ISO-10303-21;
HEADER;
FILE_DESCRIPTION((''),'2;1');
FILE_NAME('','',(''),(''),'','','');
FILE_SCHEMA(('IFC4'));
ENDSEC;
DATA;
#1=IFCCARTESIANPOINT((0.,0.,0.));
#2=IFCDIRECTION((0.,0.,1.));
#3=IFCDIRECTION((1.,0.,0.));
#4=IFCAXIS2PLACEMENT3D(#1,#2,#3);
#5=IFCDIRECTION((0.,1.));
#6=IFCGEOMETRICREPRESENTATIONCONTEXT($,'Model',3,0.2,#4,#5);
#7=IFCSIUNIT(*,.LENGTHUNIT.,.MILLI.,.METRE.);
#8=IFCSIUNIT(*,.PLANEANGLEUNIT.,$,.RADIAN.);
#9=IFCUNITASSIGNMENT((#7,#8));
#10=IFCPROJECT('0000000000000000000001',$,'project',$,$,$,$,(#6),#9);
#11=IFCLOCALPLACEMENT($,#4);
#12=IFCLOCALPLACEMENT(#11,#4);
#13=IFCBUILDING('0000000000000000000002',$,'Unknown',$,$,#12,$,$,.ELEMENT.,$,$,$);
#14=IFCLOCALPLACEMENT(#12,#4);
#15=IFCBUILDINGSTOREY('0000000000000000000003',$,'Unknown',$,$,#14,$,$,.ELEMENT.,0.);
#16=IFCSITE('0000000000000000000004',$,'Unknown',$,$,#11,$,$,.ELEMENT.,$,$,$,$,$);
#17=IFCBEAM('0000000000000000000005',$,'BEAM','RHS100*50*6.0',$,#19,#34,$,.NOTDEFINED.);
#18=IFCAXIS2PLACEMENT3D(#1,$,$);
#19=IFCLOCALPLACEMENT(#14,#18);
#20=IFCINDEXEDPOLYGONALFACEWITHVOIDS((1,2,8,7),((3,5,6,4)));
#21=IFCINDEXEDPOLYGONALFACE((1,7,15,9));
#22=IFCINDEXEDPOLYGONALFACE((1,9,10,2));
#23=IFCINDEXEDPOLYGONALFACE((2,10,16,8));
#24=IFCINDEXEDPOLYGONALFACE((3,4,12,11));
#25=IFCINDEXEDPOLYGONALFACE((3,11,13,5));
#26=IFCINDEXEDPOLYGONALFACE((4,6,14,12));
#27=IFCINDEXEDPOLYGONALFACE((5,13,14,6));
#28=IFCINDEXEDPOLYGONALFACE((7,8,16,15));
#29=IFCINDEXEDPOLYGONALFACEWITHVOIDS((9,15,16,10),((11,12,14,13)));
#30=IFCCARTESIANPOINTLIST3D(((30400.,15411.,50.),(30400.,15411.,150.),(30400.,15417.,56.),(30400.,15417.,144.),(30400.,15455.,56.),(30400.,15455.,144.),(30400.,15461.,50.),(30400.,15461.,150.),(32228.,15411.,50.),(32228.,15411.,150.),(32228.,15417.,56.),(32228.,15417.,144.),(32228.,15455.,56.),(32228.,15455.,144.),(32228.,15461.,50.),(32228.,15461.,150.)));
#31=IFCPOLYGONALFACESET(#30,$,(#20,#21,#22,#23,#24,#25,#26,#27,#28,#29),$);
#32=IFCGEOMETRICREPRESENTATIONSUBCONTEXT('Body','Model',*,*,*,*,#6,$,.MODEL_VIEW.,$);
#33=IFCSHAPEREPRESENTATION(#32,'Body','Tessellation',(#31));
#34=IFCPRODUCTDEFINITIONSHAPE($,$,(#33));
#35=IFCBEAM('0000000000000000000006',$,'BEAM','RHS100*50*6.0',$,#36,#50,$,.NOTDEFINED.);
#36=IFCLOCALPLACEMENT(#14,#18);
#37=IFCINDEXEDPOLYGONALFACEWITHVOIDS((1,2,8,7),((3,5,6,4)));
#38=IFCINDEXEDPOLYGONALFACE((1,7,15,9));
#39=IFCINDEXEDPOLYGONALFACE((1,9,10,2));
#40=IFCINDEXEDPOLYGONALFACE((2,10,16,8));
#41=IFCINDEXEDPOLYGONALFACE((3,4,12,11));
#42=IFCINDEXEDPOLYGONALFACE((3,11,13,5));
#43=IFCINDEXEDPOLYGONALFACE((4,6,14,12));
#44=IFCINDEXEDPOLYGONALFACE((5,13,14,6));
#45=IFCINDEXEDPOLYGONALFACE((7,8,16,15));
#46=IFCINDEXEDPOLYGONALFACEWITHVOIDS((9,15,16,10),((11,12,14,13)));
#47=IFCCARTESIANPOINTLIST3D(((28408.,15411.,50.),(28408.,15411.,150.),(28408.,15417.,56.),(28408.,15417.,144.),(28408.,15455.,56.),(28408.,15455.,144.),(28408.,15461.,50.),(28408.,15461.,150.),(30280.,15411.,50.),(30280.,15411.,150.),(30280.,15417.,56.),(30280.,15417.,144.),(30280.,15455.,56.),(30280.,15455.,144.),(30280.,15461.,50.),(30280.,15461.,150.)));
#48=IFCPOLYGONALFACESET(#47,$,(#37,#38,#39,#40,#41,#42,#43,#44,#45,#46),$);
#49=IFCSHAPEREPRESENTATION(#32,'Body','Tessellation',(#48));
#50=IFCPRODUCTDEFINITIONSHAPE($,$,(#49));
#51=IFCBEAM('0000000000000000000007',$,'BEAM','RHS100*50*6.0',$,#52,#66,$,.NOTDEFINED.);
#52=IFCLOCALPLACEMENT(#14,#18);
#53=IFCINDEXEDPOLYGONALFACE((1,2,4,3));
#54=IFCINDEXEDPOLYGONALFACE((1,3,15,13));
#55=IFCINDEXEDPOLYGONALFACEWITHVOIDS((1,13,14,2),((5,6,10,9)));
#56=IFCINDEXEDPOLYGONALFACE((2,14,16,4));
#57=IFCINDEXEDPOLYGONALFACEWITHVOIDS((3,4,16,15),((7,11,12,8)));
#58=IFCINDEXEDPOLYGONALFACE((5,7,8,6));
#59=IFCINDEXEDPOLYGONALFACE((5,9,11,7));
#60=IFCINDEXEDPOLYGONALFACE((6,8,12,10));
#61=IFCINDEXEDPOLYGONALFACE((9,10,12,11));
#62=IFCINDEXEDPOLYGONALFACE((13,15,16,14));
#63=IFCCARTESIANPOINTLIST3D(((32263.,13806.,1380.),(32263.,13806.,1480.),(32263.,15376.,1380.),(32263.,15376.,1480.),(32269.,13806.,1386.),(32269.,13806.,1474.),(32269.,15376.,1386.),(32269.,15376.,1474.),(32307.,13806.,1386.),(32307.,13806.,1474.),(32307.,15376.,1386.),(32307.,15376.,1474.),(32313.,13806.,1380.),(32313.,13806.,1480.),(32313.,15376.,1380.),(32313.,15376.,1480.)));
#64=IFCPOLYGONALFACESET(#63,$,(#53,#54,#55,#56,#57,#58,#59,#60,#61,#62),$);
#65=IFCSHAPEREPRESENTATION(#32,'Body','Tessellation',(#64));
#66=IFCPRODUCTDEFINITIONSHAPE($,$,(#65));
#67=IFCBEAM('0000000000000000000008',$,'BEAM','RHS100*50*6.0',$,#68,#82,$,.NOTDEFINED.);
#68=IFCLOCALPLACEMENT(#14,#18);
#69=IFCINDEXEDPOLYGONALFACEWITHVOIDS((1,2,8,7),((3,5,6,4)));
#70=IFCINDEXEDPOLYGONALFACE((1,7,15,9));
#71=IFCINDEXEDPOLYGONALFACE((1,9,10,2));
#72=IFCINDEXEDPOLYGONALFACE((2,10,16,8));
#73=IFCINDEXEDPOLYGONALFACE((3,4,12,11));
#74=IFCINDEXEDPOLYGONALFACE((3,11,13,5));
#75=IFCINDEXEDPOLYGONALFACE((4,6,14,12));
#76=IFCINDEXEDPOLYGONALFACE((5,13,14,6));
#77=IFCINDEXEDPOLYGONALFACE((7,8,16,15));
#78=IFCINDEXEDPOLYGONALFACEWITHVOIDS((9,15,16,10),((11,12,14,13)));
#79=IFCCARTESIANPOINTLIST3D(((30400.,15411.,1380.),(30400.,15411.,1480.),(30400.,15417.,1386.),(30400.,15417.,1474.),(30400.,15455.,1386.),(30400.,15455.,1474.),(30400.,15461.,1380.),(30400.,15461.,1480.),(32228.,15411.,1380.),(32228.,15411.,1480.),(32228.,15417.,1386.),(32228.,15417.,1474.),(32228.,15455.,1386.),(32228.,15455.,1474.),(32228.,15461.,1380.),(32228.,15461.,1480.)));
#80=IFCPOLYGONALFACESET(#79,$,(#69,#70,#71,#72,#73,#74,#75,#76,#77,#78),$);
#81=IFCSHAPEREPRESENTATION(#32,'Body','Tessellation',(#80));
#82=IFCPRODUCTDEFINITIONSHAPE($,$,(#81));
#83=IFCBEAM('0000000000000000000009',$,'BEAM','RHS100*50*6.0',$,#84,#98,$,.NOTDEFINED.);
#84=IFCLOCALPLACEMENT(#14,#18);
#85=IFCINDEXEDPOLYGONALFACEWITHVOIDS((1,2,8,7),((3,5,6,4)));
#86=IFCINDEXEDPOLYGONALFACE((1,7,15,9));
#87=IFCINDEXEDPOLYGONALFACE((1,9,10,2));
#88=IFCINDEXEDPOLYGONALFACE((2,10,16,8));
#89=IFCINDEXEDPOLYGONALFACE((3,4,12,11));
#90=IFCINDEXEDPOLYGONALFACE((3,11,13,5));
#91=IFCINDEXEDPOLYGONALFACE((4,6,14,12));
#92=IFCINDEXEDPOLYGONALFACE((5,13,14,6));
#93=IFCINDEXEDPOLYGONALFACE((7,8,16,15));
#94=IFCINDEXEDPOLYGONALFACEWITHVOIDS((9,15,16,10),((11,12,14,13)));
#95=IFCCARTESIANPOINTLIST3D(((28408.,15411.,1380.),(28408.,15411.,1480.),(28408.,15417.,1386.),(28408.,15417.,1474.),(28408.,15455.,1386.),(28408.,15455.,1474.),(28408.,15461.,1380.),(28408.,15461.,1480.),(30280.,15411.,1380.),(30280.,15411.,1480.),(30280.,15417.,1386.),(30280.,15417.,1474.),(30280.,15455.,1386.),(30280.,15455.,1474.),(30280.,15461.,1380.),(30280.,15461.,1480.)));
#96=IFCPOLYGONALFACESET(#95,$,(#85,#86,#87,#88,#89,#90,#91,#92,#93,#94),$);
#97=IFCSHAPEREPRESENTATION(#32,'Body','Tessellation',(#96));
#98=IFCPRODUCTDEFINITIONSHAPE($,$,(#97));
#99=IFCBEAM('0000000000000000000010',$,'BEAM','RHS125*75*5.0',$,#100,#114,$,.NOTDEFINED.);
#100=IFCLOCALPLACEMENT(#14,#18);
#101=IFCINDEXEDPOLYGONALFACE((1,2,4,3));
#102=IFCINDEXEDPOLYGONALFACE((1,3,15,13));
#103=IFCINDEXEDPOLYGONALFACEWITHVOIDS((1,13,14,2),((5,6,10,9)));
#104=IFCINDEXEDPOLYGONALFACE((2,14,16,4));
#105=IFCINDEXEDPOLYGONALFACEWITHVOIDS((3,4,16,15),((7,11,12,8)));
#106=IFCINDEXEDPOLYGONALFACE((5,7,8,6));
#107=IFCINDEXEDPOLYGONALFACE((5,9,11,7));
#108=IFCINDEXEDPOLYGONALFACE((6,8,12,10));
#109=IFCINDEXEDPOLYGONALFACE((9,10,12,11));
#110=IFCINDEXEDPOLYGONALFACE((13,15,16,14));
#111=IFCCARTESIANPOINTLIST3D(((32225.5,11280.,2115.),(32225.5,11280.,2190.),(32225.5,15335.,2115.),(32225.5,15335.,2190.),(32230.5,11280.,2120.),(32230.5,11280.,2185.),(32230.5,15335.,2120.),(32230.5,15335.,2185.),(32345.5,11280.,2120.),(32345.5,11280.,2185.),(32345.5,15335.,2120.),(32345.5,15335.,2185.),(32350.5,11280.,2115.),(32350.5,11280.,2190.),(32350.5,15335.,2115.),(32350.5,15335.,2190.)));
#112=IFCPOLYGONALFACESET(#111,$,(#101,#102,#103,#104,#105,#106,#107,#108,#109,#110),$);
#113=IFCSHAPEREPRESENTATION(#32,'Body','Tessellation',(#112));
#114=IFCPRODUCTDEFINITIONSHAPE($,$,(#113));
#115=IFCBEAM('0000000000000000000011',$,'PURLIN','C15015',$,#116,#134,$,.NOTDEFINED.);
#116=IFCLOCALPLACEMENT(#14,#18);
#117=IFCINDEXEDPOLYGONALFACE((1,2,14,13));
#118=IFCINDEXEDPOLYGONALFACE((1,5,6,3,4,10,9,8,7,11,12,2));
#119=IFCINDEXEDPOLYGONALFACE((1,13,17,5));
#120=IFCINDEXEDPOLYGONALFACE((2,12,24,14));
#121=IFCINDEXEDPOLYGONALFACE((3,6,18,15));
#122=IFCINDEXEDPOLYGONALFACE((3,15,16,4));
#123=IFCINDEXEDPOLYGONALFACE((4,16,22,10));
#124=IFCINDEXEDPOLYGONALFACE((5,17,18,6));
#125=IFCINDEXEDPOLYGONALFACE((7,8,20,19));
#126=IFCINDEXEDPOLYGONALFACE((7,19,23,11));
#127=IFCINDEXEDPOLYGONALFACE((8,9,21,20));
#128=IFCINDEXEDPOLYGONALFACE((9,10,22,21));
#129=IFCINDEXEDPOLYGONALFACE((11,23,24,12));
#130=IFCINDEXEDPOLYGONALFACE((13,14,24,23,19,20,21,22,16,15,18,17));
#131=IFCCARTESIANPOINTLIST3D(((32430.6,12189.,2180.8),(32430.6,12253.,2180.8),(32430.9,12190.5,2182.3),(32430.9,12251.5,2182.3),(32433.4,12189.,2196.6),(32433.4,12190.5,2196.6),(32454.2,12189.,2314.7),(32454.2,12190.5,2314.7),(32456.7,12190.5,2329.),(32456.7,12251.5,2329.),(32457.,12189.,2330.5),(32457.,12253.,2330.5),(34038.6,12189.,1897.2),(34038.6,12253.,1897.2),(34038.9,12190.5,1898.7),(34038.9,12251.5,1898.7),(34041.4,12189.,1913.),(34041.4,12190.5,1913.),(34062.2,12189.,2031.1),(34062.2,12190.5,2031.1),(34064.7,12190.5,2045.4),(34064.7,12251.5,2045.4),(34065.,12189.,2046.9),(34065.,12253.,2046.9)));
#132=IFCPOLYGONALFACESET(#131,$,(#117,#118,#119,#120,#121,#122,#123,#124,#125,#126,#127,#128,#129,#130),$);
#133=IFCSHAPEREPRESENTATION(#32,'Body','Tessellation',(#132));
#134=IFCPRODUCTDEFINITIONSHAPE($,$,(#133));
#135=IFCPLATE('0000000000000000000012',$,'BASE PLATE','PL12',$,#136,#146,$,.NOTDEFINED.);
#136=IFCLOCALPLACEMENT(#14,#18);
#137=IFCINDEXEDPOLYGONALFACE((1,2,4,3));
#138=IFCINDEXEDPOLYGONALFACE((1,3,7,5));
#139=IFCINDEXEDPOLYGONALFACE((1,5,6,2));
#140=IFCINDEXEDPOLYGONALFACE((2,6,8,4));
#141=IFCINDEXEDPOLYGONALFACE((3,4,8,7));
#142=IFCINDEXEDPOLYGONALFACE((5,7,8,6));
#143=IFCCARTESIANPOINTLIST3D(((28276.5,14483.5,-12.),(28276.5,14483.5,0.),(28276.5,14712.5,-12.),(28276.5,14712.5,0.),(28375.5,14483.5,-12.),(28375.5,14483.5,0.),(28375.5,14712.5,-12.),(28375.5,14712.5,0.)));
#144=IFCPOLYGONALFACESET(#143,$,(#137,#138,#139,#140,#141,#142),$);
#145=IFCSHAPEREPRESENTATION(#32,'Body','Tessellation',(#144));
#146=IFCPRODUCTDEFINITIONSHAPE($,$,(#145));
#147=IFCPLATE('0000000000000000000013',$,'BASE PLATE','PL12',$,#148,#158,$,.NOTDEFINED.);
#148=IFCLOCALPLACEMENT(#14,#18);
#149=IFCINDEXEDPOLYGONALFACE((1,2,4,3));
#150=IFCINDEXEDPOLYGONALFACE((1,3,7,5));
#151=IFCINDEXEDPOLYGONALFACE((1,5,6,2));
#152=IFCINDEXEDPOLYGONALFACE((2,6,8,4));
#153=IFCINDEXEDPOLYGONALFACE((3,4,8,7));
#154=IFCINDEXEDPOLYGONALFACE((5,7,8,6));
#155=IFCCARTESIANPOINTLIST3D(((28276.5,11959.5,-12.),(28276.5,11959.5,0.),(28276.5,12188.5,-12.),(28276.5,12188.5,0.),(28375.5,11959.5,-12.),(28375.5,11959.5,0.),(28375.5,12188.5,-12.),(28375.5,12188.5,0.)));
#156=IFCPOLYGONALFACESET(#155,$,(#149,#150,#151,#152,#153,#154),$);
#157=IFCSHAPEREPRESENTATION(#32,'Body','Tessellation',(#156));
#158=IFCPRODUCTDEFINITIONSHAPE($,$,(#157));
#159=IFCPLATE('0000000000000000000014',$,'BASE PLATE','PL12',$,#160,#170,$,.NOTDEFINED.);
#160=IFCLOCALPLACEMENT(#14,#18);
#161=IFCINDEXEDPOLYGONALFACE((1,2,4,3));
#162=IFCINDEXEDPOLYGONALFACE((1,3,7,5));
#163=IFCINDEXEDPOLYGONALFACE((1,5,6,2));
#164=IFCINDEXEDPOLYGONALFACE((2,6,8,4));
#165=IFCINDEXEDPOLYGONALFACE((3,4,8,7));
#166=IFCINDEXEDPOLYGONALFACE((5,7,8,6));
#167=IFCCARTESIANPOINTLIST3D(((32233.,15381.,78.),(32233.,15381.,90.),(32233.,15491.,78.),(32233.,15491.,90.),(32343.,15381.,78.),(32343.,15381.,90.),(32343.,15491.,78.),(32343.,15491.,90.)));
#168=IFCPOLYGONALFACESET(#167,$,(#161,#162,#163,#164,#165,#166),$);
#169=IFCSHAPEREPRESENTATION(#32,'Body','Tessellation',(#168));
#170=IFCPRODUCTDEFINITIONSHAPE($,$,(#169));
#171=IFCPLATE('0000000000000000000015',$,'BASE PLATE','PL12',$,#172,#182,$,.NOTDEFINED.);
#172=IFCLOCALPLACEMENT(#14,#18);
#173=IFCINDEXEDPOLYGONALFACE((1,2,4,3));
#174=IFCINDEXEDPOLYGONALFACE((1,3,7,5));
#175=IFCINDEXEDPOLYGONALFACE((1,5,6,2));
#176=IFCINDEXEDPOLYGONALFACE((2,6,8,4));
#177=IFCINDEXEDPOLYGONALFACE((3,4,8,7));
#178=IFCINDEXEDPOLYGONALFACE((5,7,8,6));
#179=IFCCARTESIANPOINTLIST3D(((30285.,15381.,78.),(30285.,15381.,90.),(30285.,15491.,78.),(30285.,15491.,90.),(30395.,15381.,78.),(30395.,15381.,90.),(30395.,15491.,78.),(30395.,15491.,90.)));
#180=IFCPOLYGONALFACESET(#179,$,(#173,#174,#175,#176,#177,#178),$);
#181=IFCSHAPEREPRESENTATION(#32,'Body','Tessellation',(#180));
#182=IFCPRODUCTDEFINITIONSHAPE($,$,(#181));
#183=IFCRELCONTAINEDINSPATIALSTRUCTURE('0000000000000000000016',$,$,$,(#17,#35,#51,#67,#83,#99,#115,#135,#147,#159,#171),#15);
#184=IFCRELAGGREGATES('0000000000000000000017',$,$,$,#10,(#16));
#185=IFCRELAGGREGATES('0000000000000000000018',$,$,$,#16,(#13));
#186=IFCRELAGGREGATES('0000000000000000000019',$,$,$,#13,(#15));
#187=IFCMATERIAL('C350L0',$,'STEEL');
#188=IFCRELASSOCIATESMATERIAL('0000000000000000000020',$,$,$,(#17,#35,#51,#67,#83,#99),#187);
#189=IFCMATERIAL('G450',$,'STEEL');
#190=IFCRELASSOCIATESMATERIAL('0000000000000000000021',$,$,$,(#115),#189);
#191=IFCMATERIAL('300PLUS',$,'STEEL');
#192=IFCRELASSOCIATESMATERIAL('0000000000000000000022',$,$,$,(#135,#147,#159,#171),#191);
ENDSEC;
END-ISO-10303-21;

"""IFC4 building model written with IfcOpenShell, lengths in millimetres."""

from ifc_helpers import new_model, si_unit, direction, frame, origin_with_axes, place, context, subcontext, project, spatial, line, indexed_curve, outline, extrude, material, element, save


model = new_model("IFC4")

# Units and contexts
model_context = context("Model", 3, precision=0.2, world=origin_with_axes(), true_north=direction((0.0, 1.0)))
body_context = subcontext(model_context, "Body", "Model", "MODEL_VIEW")
ifc_project = project(units=[si_unit("LENGTHUNIT", "METRE", prefix="MILLI"), si_unit("PLANEANGLEUNIT", "RADIAN")], contexts=[model_context])

# Site, building, storey
site_placement = place(None, origin_with_axes())
site = spatial("IfcSite", under=ifc_project, at=site_placement, Name="Unknown", CompositionType="ELEMENT")
building_placement = place(site_placement, origin_with_axes())
building = spatial("IfcBuilding", under=site, at=building_placement, Name="Unknown", CompositionType="ELEMENT")
storey_placement = place(building_placement, origin_with_axes())
storey = spatial("IfcBuildingStorey", under=building, at=storey_placement, Name="Unknown", CompositionType="ELEMENT", Elevation=0.0)

# Shared definitions
ifc_material_1 = material(Name="C350L0", Category="STEEL")

# Beams
beam_1_placement = place(storey_placement, frame((30400.0, 15436.0, 100.0), z_axis=(0.0, -1.0, 0.0), x_axis=(1.0, 0.0, 0.0)))
element("IfcBeam", 1, at=beam_1_placement, inside=storey, material=ifc_material_1, Name="BEAM", Description="RHS100*50*6.0", PredefinedType="NOTDEFINED", context=body_context, shape_type="SolidModel", body=[
    extrude(outline(indexed_curve([(-25.0, -50.0), (25.0, -50.0), (25.0, 50.0), (-25.0, 50.0)], segments=[line(1, 2, 3, 4, 1)]), holes=[indexed_curve([(-19.0, -44.0), (-19.0, 44.0), (19.0, 44.0), (19.0, -44.0)], segments=[line(1, 2, 3, 4, 1)])]), frame((0.0, 0.0, 0.0), z_axis=(-1.0, 0.0, 0.0), x_axis=(0.0, 0.0, 1.0)), (0.0, 0.0, -1.0), 1828.0),
])
beam_2_placement = place(storey_placement, frame((28408.0, 15436.0, 100.0), z_axis=(0.0, -1.0, 0.0), x_axis=(1.0, 0.0, 0.0)))
element("IfcBeam", 2, at=beam_2_placement, inside=storey, material=ifc_material_1, Name="BEAM", Description="RHS100*50*6.0", PredefinedType="NOTDEFINED", context=body_context, shape_type="SolidModel", body=[
    extrude(outline(indexed_curve([(-25.0, -50.0), (25.0, -50.0), (25.0, 50.0), (-25.0, 50.0)], segments=[line(1, 2, 3, 4, 1)]), holes=[indexed_curve([(-19.0, -44.0), (-19.0, 44.0), (19.0, 44.0), (19.0, -44.0)], segments=[line(1, 2, 3, 4, 1)])]), frame((0.0, 0.0, 0.0), z_axis=(-1.0, 0.0, 0.0), x_axis=(0.0, 0.0, 1.0)), (0.0, 0.0, -1.0), 1872.0),
])
beam_3_placement = place(storey_placement, frame((32288.0, 13806.0, 1430.0), z_axis=(1.0, 0.0, 0.0), x_axis=(0.0, 1.0, 0.0)))
element("IfcBeam", 3, at=beam_3_placement, inside=storey, material=ifc_material_1, Name="BEAM", Description="RHS100*50*6.0", PredefinedType="NOTDEFINED", context=body_context, shape_type="SolidModel", body=[
    extrude(outline(indexed_curve([(-25.0, -50.0), (25.0, -50.0), (25.0, 50.0), (-25.0, 50.0)], segments=[line(1, 2, 3, 4, 1)]), holes=[indexed_curve([(-19.0, -44.0), (-19.0, 44.0), (19.0, 44.0), (19.0, -44.0)], segments=[line(1, 2, 3, 4, 1)])]), frame((0.0, 0.0, 0.0), z_axis=(-1.0, 0.0, 0.0), x_axis=(0.0, 0.0, 1.0)), (0.0, 0.0, -1.0), 1570.0),
])
beam_4_placement = place(storey_placement, frame((30400.0, 15436.0, 1430.0), z_axis=(0.0, -1.0, 0.0), x_axis=(1.0, 0.0, 0.0)))
element("IfcBeam", 4, at=beam_4_placement, inside=storey, material=ifc_material_1, Name="BEAM", Description="RHS100*50*6.0", PredefinedType="NOTDEFINED", context=body_context, shape_type="SolidModel", body=[
    extrude(outline(indexed_curve([(-25.0, -50.0), (25.0, -50.0), (25.0, 50.0), (-25.0, 50.0)], segments=[line(1, 2, 3, 4, 1)]), holes=[indexed_curve([(-19.0, -44.0), (-19.0, 44.0), (19.0, 44.0), (19.0, -44.0)], segments=[line(1, 2, 3, 4, 1)])]), frame((0.0, 0.0, 0.0), z_axis=(-1.0, 0.0, 0.0), x_axis=(0.0, 0.0, 1.0)), (0.0, 0.0, -1.0), 1828.0),
])
beam_5_placement = place(storey_placement, frame((28408.0, 15436.0, 1430.0), z_axis=(0.0, -1.0, 0.0), x_axis=(1.0, 0.0, 0.0)))
element("IfcBeam", 5, at=beam_5_placement, inside=storey, material=ifc_material_1, Name="BEAM", Description="RHS100*50*6.0", PredefinedType="NOTDEFINED", context=body_context, shape_type="SolidModel", body=[
    extrude(outline(indexed_curve([(-25.0, -50.0), (25.0, -50.0), (25.0, 50.0), (-25.0, 50.0)], segments=[line(1, 2, 3, 4, 1)]), holes=[indexed_curve([(-19.0, -44.0), (-19.0, 44.0), (19.0, 44.0), (19.0, -44.0)], segments=[line(1, 2, 3, 4, 1)])]), frame((0.0, 0.0, 0.0), z_axis=(-1.0, 0.0, 0.0), x_axis=(0.0, 0.0, 1.0)), (0.0, 0.0, -1.0), 1872.0),
])
beam_6_placement = place(storey_placement, frame((32288.0, 11280.0, 2152.5), z_axis=(0.0, 0.0, 1.0), x_axis=(0.0, 1.0, 0.0)))
element("IfcBeam", 6, at=beam_6_placement, inside=storey, material=ifc_material_1, Name="BEAM", Description="RHS125*75*5.0", PredefinedType="NOTDEFINED", context=body_context, shape_type="SolidModel", body=[
    extrude(outline(indexed_curve([(-37.5, -62.5), (37.5, -62.5), (37.5, 62.5), (-37.5, 62.5)], segments=[line(1, 2, 3, 4, 1)]), holes=[indexed_curve([(-32.5, -57.5), (-32.5, 57.5), (32.5, 57.5), (32.5, -57.5)], segments=[line(1, 2, 3, 4, 1)])]), frame((0.0, 0.0, 0.0), z_axis=(-1.0, 0.0, 0.0), x_axis=(0.0, 0.0, 1.0)), (0.0, 0.0, -1.0), 4055.0),
])
ifc_material_2 = material(Name="G450", Category="STEEL")
beam_7_placement = place(storey_placement, frame((32443.8, 12221.0, 2255.7), z_axis=(0.0, -1.0, 0.0), x_axis=(0.984801, 0.0, -0.173688)))
element("IfcBeam", 7, at=beam_7_placement, inside=storey, material=ifc_material_2, Name="PURLIN", Description="C15015", PredefinedType="NOTDEFINED", context=body_context, shape_type="SolidModel", body=[
    extrude(outline(indexed_curve([(32.0, -76.0), (32.0, -60.0), (30.5, -60.0), (30.5, -74.5), (-30.5, -74.5), (-30.5, 74.5), (30.5, 74.5), (30.5, 60.0), (32.0, 60.0), (32.0, 76.0), (-32.0, 76.0), (-32.0, -76.0)], segments=[line(1, 2, 3, 4, 5, 6, 7, 8, 9, 10, 11, 12, 1)])), frame((0.0, 0.0, 0.0), z_axis=(-1.0, 0.0, 0.0), x_axis=(0.0, 0.0, 1.0)), (0.0, 0.0, -1.0), 1632.8),
])

# Plates
ifc_material_3 = material(Name="300PLUS", Category="STEEL")
for number, where, z_axis, x_axis, name in (
    (8, (28276.5, 14483.5, -6.0), (0.0, 0.0, 1.0), (1.0, 0.0, 0.0), "BASE PLATE"),
    (9, (28276.5, 11959.5, -6.0), (0.0, 0.0, 1.0), (1.0, 0.0, 0.0), "BASE PLATE"),
):
    element("IfcPlate", number, at=place(storey_placement, frame(where, z_axis=z_axis, x_axis=x_axis)), inside=storey, material=ifc_material_3, Name=name, Description="PL12", PredefinedType="NOTDEFINED", context=body_context, shape_type="SolidModel", body=[
        extrude(outline(indexed_curve([(0.0, 0.0), (99.0, 0.0), (99.0, 229.0), (0.0, 229.0)], segments=[line(1, 2, 3, 4, 1)])), frame((0.0, 0.0, 6.0), z_axis=(0.0, 0.0, 1.0), x_axis=(1.0, 0.0, 0.0)), (0.0, 0.0, -1.0), 12.0),
    ])
for number, where, z_axis, x_axis, name in (
    (10, (32233.0, 15381.0, 84.0), (0.0, 0.0, 1.0), (1.0, 0.0, 0.0), "BASE PLATE"),
    (11, (30285.0, 15381.0, 84.0), (0.0, 0.0, 1.0), (1.0, 0.0, 0.0), "BASE PLATE"),
):
    element("IfcPlate", number, at=place(storey_placement, frame(where, z_axis=z_axis, x_axis=x_axis)), inside=storey, material=ifc_material_3, Name=name, Description="PL12", PredefinedType="NOTDEFINED", context=body_context, shape_type="SolidModel", body=[
        extrude(outline(indexed_curve([(0.0, 0.0), (110.0, 0.0), (110.0, 110.0), (0.0, 110.0)], segments=[line(1, 2, 3, 4, 1)])), frame((0.0, 0.0, 6.0), z_axis=(0.0, 0.0, 1.0), x_axis=(1.0, 0.0, 0.0)), (0.0, 0.0, -1.0), 12.0),
    ])

save(model, "model.ifc")
